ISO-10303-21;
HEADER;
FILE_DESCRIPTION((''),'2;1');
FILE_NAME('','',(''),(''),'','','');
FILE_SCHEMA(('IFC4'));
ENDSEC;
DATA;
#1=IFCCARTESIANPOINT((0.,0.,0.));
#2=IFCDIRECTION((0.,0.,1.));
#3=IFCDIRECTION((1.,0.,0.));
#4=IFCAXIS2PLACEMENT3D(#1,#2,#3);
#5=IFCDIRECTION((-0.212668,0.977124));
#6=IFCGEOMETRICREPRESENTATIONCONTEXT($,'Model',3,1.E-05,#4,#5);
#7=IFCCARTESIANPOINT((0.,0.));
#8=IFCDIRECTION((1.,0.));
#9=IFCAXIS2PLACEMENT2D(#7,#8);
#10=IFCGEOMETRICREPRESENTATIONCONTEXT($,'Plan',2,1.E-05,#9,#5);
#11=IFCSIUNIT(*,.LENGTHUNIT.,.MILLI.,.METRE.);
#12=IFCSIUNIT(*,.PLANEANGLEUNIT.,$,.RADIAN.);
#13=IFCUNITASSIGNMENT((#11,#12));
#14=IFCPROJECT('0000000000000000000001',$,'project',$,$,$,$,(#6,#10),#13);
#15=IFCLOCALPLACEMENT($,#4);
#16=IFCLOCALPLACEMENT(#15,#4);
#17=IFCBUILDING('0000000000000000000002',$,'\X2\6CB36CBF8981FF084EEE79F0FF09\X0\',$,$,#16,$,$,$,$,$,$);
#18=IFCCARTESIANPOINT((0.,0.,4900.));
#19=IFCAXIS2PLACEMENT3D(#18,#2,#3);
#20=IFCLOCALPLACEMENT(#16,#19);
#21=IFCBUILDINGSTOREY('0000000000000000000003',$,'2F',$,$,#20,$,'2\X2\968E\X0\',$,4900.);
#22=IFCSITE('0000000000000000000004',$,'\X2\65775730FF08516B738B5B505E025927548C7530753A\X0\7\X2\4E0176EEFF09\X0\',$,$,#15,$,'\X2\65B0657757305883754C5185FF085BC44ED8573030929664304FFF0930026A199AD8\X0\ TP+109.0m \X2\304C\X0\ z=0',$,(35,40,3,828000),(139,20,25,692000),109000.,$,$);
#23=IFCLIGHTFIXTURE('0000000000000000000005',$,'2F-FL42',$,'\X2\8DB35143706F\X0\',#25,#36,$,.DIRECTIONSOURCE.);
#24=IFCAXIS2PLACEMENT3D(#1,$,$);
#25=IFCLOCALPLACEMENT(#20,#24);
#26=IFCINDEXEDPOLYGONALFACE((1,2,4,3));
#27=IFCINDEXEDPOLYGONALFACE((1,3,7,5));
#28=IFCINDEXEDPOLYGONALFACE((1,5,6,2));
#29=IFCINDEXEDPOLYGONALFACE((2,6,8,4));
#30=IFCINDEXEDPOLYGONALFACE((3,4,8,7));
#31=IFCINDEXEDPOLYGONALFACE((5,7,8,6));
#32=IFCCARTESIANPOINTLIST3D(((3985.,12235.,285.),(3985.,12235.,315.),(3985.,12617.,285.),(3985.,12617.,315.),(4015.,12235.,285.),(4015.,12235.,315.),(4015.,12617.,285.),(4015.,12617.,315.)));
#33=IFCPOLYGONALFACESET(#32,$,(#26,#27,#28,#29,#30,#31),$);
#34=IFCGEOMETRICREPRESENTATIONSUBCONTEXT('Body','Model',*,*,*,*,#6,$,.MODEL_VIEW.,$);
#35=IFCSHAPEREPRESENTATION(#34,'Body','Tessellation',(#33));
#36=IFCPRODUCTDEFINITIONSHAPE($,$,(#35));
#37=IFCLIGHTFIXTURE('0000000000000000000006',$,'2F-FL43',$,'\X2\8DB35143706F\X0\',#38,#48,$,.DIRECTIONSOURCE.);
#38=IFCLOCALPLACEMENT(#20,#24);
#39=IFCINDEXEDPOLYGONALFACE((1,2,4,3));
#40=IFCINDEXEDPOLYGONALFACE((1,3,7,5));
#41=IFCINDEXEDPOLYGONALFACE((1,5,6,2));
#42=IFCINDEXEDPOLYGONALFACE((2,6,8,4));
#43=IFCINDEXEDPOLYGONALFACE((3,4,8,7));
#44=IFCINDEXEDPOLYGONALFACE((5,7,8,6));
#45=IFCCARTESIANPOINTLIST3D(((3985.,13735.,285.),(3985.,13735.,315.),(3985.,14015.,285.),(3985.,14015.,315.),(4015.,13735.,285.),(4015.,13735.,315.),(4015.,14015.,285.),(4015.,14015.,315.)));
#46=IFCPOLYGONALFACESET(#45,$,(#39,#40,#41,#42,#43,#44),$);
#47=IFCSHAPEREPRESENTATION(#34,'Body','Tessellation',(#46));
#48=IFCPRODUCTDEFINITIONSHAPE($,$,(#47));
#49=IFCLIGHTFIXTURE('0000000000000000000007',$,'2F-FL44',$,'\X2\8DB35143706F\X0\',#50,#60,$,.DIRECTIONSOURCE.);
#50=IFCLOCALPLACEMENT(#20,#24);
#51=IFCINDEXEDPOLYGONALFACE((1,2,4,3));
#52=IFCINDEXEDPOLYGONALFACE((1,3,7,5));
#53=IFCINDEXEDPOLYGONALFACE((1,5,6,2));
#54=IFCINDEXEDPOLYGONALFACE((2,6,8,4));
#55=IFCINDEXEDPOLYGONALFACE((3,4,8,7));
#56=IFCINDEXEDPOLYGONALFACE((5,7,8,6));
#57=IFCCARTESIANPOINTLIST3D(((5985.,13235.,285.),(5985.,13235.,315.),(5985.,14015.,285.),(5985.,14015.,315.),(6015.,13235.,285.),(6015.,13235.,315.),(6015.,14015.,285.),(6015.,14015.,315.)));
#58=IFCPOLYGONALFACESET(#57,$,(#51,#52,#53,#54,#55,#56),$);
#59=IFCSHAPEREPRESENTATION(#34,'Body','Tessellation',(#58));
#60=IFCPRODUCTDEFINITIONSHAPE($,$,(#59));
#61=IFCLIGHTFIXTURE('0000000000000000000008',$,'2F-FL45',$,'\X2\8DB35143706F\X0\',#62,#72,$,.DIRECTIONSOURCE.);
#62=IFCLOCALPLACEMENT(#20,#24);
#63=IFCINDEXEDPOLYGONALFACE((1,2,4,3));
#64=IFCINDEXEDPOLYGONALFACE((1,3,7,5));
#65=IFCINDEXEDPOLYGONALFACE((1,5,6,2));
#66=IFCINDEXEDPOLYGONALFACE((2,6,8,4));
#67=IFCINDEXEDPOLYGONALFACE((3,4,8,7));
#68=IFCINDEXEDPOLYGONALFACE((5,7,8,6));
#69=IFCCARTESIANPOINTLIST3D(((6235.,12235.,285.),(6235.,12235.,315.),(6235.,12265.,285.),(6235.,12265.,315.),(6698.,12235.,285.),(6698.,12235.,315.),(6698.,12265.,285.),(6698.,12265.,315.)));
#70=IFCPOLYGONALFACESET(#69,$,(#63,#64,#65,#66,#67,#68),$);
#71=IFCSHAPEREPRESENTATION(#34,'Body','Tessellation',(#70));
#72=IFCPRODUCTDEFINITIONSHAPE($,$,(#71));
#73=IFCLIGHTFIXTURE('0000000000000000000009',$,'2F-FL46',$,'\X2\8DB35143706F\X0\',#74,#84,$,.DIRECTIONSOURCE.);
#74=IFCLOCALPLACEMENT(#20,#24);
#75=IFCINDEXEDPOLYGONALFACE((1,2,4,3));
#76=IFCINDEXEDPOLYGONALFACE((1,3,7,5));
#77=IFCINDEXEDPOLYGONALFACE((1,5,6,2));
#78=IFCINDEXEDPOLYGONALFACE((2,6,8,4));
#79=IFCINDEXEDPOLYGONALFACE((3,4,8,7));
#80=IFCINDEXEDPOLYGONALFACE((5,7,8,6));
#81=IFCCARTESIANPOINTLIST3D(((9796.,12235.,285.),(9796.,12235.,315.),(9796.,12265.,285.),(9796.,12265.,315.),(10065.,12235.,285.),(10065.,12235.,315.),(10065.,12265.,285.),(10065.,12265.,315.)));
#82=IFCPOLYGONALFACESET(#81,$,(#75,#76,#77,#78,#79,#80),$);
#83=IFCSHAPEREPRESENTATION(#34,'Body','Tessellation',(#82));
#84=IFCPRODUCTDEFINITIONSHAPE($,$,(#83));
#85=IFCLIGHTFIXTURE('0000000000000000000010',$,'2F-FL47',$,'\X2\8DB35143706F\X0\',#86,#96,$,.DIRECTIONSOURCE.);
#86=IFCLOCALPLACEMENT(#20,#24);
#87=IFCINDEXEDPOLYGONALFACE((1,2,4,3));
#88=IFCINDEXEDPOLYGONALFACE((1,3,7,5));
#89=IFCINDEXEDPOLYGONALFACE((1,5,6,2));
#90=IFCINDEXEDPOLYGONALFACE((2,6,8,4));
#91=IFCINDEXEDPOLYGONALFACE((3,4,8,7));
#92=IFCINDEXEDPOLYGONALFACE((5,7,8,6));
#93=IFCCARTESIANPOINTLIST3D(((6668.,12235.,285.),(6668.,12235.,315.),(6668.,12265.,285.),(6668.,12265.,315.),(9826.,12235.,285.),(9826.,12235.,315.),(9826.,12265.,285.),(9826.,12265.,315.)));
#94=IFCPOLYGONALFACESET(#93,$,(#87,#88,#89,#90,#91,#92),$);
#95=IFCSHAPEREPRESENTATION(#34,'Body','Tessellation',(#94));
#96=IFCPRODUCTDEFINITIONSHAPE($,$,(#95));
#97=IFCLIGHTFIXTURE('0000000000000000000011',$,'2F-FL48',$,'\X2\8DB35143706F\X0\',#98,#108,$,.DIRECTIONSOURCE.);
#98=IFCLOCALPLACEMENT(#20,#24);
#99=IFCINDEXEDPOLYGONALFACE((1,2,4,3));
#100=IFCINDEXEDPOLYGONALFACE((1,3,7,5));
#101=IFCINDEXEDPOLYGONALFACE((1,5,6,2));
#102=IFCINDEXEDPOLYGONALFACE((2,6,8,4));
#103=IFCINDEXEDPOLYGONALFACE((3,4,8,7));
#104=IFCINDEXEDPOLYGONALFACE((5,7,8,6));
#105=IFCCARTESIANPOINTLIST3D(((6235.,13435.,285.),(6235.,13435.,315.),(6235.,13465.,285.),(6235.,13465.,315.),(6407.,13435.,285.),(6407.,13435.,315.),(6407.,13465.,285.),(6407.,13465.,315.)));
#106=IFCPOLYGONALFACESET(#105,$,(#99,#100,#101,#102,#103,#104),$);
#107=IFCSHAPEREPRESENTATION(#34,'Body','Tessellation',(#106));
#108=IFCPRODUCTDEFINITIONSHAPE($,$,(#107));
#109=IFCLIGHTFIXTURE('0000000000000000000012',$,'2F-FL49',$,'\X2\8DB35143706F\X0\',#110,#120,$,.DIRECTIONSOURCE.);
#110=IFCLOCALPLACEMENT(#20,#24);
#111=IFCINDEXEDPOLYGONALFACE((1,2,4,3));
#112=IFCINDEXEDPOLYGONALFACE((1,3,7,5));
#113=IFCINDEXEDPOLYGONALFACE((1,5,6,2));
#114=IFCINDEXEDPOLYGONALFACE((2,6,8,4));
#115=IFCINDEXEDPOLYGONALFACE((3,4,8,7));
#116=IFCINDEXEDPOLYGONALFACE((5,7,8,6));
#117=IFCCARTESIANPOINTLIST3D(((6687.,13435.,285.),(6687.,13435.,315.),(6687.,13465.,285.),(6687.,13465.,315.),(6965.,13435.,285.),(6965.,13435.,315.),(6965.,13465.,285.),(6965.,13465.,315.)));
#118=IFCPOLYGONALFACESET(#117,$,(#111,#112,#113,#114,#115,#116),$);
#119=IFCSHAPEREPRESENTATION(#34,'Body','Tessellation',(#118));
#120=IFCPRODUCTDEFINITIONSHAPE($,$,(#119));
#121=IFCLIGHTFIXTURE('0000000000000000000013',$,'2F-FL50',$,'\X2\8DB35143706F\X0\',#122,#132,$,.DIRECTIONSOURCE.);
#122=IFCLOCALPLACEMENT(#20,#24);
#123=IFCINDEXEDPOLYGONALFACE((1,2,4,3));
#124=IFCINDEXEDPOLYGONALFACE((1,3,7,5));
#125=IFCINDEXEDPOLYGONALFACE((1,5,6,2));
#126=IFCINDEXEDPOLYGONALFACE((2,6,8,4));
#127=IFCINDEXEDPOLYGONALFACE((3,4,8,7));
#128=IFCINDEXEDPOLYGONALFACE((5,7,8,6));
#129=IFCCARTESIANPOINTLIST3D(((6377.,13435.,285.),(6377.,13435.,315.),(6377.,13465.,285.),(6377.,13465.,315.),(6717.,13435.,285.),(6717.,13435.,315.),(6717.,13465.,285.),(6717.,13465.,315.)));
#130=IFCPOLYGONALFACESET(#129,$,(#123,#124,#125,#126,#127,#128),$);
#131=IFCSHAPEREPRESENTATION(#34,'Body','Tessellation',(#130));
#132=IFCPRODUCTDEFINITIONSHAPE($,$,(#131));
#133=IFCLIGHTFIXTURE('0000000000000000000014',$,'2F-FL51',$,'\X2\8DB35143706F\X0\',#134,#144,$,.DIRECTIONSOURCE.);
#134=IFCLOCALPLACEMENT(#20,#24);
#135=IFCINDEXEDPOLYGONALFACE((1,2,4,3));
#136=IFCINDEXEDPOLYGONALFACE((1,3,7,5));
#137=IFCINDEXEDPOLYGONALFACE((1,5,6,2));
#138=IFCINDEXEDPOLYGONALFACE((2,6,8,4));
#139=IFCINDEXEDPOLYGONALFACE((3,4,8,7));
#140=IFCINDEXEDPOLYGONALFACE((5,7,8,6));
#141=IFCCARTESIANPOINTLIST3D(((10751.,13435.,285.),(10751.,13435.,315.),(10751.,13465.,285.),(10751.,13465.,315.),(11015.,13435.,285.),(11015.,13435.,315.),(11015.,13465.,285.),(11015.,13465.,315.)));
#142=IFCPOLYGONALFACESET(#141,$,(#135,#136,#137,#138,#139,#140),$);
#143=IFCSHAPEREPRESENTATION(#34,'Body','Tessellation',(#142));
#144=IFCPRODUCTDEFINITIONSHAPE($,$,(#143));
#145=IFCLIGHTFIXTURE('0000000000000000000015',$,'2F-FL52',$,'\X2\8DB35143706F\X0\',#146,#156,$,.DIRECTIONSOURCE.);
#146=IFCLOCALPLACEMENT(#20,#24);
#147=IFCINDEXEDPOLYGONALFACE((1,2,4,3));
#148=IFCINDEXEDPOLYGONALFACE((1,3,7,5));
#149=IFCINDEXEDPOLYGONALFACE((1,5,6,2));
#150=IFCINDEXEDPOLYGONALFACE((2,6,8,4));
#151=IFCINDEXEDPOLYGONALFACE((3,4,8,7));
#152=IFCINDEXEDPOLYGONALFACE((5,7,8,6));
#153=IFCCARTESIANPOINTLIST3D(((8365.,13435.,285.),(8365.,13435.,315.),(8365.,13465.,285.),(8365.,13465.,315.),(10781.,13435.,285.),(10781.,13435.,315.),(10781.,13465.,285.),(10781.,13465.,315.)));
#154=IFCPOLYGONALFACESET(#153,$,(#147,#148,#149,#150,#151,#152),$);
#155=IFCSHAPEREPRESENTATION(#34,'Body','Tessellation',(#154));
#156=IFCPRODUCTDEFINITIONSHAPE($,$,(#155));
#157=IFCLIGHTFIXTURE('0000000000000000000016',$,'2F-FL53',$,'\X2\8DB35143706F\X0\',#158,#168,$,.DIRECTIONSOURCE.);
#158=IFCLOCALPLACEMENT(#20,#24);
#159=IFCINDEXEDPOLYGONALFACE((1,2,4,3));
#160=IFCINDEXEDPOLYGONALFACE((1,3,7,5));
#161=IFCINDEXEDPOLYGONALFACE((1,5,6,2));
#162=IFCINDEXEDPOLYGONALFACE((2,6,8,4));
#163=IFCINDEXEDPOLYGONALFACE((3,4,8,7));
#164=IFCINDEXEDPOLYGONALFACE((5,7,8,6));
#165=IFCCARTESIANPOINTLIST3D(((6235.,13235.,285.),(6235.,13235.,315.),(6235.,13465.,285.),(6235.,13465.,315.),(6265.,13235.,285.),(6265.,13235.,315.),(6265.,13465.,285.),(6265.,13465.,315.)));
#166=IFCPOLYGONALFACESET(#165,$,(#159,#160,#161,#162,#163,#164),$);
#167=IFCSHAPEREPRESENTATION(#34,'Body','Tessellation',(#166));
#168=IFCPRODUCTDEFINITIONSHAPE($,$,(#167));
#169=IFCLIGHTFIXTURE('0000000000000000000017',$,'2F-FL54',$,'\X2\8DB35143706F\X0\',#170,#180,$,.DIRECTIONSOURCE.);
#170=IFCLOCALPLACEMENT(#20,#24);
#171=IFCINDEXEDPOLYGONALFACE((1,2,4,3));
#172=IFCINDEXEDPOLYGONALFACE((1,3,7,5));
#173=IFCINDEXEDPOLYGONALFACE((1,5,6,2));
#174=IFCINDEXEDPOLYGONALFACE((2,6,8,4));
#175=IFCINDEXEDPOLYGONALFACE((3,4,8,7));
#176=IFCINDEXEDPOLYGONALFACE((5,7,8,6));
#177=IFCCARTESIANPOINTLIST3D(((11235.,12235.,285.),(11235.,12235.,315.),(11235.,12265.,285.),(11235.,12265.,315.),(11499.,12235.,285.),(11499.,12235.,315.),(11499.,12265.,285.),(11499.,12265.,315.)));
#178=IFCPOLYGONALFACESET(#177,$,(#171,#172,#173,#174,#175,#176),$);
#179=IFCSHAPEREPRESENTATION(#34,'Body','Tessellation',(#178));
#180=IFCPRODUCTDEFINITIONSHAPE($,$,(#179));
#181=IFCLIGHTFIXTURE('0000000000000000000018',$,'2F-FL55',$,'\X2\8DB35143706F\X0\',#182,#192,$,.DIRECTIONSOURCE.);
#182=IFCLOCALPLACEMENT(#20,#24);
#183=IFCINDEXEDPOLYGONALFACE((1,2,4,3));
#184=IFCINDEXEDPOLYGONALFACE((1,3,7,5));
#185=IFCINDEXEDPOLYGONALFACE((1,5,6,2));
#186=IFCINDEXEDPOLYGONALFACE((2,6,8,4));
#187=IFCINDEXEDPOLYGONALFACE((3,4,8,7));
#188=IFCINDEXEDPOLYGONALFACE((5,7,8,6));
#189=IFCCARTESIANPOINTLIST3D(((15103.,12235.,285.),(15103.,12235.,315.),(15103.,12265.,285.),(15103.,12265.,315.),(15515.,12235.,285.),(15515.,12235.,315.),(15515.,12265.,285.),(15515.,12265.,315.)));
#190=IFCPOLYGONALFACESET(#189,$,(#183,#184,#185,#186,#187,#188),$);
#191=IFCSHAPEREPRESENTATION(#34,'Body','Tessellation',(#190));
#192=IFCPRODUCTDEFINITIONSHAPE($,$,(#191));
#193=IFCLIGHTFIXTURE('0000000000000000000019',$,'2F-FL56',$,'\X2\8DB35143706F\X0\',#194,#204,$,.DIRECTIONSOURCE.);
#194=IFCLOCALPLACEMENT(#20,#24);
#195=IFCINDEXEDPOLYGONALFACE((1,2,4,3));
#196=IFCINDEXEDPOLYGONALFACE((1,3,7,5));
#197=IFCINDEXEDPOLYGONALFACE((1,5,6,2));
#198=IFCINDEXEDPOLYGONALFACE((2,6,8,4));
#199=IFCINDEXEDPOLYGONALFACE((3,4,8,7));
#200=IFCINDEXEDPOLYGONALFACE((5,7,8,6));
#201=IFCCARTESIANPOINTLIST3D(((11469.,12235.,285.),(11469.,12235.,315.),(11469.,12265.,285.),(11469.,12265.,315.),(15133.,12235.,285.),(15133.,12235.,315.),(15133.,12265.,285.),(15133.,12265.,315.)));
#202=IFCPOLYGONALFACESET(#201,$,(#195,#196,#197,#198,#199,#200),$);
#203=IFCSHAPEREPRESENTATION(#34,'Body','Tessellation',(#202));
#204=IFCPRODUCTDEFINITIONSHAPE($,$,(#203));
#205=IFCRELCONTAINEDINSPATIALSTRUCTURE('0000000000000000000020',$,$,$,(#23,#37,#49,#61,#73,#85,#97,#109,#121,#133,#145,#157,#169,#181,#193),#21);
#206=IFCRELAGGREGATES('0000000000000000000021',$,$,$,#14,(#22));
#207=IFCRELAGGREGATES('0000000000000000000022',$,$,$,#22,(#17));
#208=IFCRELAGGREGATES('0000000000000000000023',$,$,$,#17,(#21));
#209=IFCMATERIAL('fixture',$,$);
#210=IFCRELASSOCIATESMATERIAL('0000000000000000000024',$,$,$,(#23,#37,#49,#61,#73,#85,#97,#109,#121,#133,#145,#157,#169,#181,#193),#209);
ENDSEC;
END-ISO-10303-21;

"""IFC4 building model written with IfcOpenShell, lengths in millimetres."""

from ifc_helpers import new_model, si_unit, direction, frame, frame_2d, origin_with_axes, origin_2d_with_axis, place, context, subcontext, project, spatial, rectangle, extrude, material, element, save


model = new_model("IFC4")

# Units and contexts
model_context = context("Model", 3, precision=1e-05, world=origin_with_axes(), true_north=direction((-0.212668, 0.977124)))
plan_context = context("Plan", 2, precision=1e-05, world=origin_2d_with_axis(), true_north=direction((-0.212668, 0.977124)))
body_context = subcontext(model_context, "Body", "Model", "MODEL_VIEW")
ifc_project = project(units=[si_unit("LENGTHUNIT", "METRE", prefix="MILLI"), si_unit("PLANEANGLEUNIT", "RADIAN")], contexts=[model_context, plan_context])

# Site, building, storey
site_placement = place(None, origin_with_axes())
site = spatial("IfcSite", under=ifc_project, at=site_placement, Name="敷地（八王子市大和田町7丁目）", LongName="新敷地境界内（寄付地を除く）。標高 TP+109.0m が z=0", RefLatitude=(35, 40, 3, 828000), RefLongitude=(139, 20, 25, 692000), RefElevation=109000.0)
building_placement = place(site_placement, origin_with_axes())
building = spatial("IfcBuilding", under=site, at=building_placement, Name="河沿要（仮称）")
storey_placement = place(building_placement, frame((0.0, 0.0, 4900.0), z_axis=(0.0, 0.0, 1.0), x_axis=(1.0, 0.0, 0.0)))
storey = spatial("IfcBuildingStorey", under=building, at=storey_placement, Name="2F", LongName="2階", Elevation=4900.0)

# Light fixtures
ifc_material = material(Name="fixture")
light_fixture_1_placement = place(storey_placement, origin_with_axes())
element("IfcLightFixture", 1, at=light_fixture_1_placement, inside=storey, material=ifc_material, Name="2F-FL42", ObjectType="足元灯", PredefinedType="DIRECTIONSOURCE", context=body_context, shape_type="SweptSolid", body=[
    extrude(rectangle(XDim=30.0, YDim=382.0, at=frame_2d((4000.0, 12426.0))), frame((0.0, 0.0, 285.0)), (0.0, 0.0, 1.0), 30.0),
])
light_fixture_2_placement = place(storey_placement, origin_with_axes())
element("IfcLightFixture", 2, at=light_fixture_2_placement, inside=storey, material=ifc_material, Name="2F-FL43", ObjectType="足元灯", PredefinedType="DIRECTIONSOURCE", context=body_context, shape_type="SweptSolid", body=[
    extrude(rectangle(XDim=30.0, YDim=280.0, at=frame_2d((4000.0, 13875.0))), frame((0.0, 0.0, 285.0)), (0.0, 0.0, 1.0), 30.0),
])
light_fixture_3_placement = place(storey_placement, origin_with_axes())
element("IfcLightFixture", 3, at=light_fixture_3_placement, inside=storey, material=ifc_material, Name="2F-FL44", ObjectType="足元灯", PredefinedType="DIRECTIONSOURCE", context=body_context, shape_type="SweptSolid", body=[
    extrude(rectangle(XDim=30.0, YDim=780.0, at=frame_2d((6000.0, 13625.0))), frame((0.0, 0.0, 285.0)), (0.0, 0.0, 1.0), 30.0),
])
light_fixture_4_placement = place(storey_placement, origin_with_axes())
element("IfcLightFixture", 4, at=light_fixture_4_placement, inside=storey, material=ifc_material, Name="2F-FL45", ObjectType="足元灯", PredefinedType="DIRECTIONSOURCE", context=body_context, shape_type="SweptSolid", body=[
    extrude(rectangle(XDim=463.0, YDim=30.0, at=frame_2d((6466.5, 12250.0))), frame((0.0, 0.0, 285.0)), (0.0, 0.0, 1.0), 30.0),
])
light_fixture_5_placement = place(storey_placement, origin_with_axes())
element("IfcLightFixture", 5, at=light_fixture_5_placement, inside=storey, material=ifc_material, Name="2F-FL46", ObjectType="足元灯", PredefinedType="DIRECTIONSOURCE", context=body_context, shape_type="SweptSolid", body=[
    extrude(rectangle(XDim=269.0, YDim=30.0, at=frame_2d((9930.5, 12250.0))), frame((0.0, 0.0, 285.0)), (0.0, 0.0, 1.0), 30.0),
])
light_fixture_6_placement = place(storey_placement, origin_with_axes())
element("IfcLightFixture", 6, at=light_fixture_6_placement, inside=storey, material=ifc_material, Name="2F-FL47", ObjectType="足元灯", PredefinedType="DIRECTIONSOURCE", context=body_context, shape_type="SweptSolid", body=[
    extrude(rectangle(XDim=3158.0, YDim=30.0, at=frame_2d((8247.0, 12250.0))), frame((0.0, 0.0, 285.0)), (0.0, 0.0, 1.0), 30.0),
])
light_fixture_7_placement = place(storey_placement, origin_with_axes())
element("IfcLightFixture", 7, at=light_fixture_7_placement, inside=storey, material=ifc_material, Name="2F-FL48", ObjectType="足元灯", PredefinedType="DIRECTIONSOURCE", context=body_context, shape_type="SweptSolid", body=[
    extrude(rectangle(XDim=172.0, YDim=30.0, at=frame_2d((6321.0, 13450.0))), frame((0.0, 0.0, 285.0)), (0.0, 0.0, 1.0), 30.0),
])
light_fixture_8_placement = place(storey_placement, origin_with_axes())
element("IfcLightFixture", 8, at=light_fixture_8_placement, inside=storey, material=ifc_material, Name="2F-FL49", ObjectType="足元灯", PredefinedType="DIRECTIONSOURCE", context=body_context, shape_type="SweptSolid", body=[
    extrude(rectangle(XDim=278.0, YDim=30.0, at=frame_2d((6826.0, 13450.0))), frame((0.0, 0.0, 285.0)), (0.0, 0.0, 1.0), 30.0),
])
light_fixture_9_placement = place(storey_placement, origin_with_axes())
element("IfcLightFixture", 9, at=light_fixture_9_placement, inside=storey, material=ifc_material, Name="2F-FL50", ObjectType="足元灯", PredefinedType="DIRECTIONSOURCE", context=body_context, shape_type="SweptSolid", body=[
    extrude(rectangle(XDim=340.0, YDim=30.0, at=frame_2d((6547.0, 13450.0))), frame((0.0, 0.0, 285.0)), (0.0, 0.0, 1.0), 30.0),
])
light_fixture_10_placement = place(storey_placement, origin_with_axes())
element("IfcLightFixture", 10, at=light_fixture_10_placement, inside=storey, material=ifc_material, Name="2F-FL51", ObjectType="足元灯", PredefinedType="DIRECTIONSOURCE", context=body_context, shape_type="SweptSolid", body=[
    extrude(rectangle(XDim=264.0, YDim=30.0, at=frame_2d((10883.0, 13450.0))), frame((0.0, 0.0, 285.0)), (0.0, 0.0, 1.0), 30.0),
])
light_fixture_11_placement = place(storey_placement, origin_with_axes())
element("IfcLightFixture", 11, at=light_fixture_11_placement, inside=storey, material=ifc_material, Name="2F-FL52", ObjectType="足元灯", PredefinedType="DIRECTIONSOURCE", context=body_context, shape_type="SweptSolid", body=[
    extrude(rectangle(XDim=2416.0, YDim=30.0, at=frame_2d((9573.0, 13450.0))), frame((0.0, 0.0, 285.0)), (0.0, 0.0, 1.0), 30.0),
])
light_fixture_12_placement = place(storey_placement, origin_with_axes())
element("IfcLightFixture", 12, at=light_fixture_12_placement, inside=storey, material=ifc_material, Name="2F-FL53", ObjectType="足元灯", PredefinedType="DIRECTIONSOURCE", context=body_context, shape_type="SweptSolid", body=[
    extrude(rectangle(XDim=30.0, YDim=230.0, at=frame_2d((6250.0, 13350.0))), frame((0.0, 0.0, 285.0)), (0.0, 0.0, 1.0), 30.0),
])
light_fixture_13_placement = place(storey_placement, origin_with_axes())
element("IfcLightFixture", 13, at=light_fixture_13_placement, inside=storey, material=ifc_material, Name="2F-FL54", ObjectType="足元灯", PredefinedType="DIRECTIONSOURCE", context=body_context, shape_type="SweptSolid", body=[
    extrude(rectangle(XDim=264.0, YDim=30.0, at=frame_2d((11367.0, 12250.0))), frame((0.0, 0.0, 285.0)), (0.0, 0.0, 1.0), 30.0),
])
light_fixture_14_placement = place(storey_placement, origin_with_axes())
element("IfcLightFixture", 14, at=light_fixture_14_placement, inside=storey, material=ifc_material, Name="2F-FL55", ObjectType="足元灯", PredefinedType="DIRECTIONSOURCE", context=body_context, shape_type="SweptSolid", body=[
    extrude(rectangle(XDim=412.0, YDim=30.0, at=frame_2d((15309.0, 12250.0))), frame((0.0, 0.0, 285.0)), (0.0, 0.0, 1.0), 30.0),
])
light_fixture_15_placement = place(storey_placement, origin_with_axes())
element("IfcLightFixture", 15, at=light_fixture_15_placement, inside=storey, material=ifc_material, Name="2F-FL56", ObjectType="足元灯", PredefinedType="DIRECTIONSOURCE", context=body_context, shape_type="SweptSolid", body=[
    extrude(rectangle(XDim=3664.0, YDim=30.0, at=frame_2d((13301.0, 12250.0))), frame((0.0, 0.0, 285.0)), (0.0, 0.0, 1.0), 30.0),
])

save(model, "model.ifc")
